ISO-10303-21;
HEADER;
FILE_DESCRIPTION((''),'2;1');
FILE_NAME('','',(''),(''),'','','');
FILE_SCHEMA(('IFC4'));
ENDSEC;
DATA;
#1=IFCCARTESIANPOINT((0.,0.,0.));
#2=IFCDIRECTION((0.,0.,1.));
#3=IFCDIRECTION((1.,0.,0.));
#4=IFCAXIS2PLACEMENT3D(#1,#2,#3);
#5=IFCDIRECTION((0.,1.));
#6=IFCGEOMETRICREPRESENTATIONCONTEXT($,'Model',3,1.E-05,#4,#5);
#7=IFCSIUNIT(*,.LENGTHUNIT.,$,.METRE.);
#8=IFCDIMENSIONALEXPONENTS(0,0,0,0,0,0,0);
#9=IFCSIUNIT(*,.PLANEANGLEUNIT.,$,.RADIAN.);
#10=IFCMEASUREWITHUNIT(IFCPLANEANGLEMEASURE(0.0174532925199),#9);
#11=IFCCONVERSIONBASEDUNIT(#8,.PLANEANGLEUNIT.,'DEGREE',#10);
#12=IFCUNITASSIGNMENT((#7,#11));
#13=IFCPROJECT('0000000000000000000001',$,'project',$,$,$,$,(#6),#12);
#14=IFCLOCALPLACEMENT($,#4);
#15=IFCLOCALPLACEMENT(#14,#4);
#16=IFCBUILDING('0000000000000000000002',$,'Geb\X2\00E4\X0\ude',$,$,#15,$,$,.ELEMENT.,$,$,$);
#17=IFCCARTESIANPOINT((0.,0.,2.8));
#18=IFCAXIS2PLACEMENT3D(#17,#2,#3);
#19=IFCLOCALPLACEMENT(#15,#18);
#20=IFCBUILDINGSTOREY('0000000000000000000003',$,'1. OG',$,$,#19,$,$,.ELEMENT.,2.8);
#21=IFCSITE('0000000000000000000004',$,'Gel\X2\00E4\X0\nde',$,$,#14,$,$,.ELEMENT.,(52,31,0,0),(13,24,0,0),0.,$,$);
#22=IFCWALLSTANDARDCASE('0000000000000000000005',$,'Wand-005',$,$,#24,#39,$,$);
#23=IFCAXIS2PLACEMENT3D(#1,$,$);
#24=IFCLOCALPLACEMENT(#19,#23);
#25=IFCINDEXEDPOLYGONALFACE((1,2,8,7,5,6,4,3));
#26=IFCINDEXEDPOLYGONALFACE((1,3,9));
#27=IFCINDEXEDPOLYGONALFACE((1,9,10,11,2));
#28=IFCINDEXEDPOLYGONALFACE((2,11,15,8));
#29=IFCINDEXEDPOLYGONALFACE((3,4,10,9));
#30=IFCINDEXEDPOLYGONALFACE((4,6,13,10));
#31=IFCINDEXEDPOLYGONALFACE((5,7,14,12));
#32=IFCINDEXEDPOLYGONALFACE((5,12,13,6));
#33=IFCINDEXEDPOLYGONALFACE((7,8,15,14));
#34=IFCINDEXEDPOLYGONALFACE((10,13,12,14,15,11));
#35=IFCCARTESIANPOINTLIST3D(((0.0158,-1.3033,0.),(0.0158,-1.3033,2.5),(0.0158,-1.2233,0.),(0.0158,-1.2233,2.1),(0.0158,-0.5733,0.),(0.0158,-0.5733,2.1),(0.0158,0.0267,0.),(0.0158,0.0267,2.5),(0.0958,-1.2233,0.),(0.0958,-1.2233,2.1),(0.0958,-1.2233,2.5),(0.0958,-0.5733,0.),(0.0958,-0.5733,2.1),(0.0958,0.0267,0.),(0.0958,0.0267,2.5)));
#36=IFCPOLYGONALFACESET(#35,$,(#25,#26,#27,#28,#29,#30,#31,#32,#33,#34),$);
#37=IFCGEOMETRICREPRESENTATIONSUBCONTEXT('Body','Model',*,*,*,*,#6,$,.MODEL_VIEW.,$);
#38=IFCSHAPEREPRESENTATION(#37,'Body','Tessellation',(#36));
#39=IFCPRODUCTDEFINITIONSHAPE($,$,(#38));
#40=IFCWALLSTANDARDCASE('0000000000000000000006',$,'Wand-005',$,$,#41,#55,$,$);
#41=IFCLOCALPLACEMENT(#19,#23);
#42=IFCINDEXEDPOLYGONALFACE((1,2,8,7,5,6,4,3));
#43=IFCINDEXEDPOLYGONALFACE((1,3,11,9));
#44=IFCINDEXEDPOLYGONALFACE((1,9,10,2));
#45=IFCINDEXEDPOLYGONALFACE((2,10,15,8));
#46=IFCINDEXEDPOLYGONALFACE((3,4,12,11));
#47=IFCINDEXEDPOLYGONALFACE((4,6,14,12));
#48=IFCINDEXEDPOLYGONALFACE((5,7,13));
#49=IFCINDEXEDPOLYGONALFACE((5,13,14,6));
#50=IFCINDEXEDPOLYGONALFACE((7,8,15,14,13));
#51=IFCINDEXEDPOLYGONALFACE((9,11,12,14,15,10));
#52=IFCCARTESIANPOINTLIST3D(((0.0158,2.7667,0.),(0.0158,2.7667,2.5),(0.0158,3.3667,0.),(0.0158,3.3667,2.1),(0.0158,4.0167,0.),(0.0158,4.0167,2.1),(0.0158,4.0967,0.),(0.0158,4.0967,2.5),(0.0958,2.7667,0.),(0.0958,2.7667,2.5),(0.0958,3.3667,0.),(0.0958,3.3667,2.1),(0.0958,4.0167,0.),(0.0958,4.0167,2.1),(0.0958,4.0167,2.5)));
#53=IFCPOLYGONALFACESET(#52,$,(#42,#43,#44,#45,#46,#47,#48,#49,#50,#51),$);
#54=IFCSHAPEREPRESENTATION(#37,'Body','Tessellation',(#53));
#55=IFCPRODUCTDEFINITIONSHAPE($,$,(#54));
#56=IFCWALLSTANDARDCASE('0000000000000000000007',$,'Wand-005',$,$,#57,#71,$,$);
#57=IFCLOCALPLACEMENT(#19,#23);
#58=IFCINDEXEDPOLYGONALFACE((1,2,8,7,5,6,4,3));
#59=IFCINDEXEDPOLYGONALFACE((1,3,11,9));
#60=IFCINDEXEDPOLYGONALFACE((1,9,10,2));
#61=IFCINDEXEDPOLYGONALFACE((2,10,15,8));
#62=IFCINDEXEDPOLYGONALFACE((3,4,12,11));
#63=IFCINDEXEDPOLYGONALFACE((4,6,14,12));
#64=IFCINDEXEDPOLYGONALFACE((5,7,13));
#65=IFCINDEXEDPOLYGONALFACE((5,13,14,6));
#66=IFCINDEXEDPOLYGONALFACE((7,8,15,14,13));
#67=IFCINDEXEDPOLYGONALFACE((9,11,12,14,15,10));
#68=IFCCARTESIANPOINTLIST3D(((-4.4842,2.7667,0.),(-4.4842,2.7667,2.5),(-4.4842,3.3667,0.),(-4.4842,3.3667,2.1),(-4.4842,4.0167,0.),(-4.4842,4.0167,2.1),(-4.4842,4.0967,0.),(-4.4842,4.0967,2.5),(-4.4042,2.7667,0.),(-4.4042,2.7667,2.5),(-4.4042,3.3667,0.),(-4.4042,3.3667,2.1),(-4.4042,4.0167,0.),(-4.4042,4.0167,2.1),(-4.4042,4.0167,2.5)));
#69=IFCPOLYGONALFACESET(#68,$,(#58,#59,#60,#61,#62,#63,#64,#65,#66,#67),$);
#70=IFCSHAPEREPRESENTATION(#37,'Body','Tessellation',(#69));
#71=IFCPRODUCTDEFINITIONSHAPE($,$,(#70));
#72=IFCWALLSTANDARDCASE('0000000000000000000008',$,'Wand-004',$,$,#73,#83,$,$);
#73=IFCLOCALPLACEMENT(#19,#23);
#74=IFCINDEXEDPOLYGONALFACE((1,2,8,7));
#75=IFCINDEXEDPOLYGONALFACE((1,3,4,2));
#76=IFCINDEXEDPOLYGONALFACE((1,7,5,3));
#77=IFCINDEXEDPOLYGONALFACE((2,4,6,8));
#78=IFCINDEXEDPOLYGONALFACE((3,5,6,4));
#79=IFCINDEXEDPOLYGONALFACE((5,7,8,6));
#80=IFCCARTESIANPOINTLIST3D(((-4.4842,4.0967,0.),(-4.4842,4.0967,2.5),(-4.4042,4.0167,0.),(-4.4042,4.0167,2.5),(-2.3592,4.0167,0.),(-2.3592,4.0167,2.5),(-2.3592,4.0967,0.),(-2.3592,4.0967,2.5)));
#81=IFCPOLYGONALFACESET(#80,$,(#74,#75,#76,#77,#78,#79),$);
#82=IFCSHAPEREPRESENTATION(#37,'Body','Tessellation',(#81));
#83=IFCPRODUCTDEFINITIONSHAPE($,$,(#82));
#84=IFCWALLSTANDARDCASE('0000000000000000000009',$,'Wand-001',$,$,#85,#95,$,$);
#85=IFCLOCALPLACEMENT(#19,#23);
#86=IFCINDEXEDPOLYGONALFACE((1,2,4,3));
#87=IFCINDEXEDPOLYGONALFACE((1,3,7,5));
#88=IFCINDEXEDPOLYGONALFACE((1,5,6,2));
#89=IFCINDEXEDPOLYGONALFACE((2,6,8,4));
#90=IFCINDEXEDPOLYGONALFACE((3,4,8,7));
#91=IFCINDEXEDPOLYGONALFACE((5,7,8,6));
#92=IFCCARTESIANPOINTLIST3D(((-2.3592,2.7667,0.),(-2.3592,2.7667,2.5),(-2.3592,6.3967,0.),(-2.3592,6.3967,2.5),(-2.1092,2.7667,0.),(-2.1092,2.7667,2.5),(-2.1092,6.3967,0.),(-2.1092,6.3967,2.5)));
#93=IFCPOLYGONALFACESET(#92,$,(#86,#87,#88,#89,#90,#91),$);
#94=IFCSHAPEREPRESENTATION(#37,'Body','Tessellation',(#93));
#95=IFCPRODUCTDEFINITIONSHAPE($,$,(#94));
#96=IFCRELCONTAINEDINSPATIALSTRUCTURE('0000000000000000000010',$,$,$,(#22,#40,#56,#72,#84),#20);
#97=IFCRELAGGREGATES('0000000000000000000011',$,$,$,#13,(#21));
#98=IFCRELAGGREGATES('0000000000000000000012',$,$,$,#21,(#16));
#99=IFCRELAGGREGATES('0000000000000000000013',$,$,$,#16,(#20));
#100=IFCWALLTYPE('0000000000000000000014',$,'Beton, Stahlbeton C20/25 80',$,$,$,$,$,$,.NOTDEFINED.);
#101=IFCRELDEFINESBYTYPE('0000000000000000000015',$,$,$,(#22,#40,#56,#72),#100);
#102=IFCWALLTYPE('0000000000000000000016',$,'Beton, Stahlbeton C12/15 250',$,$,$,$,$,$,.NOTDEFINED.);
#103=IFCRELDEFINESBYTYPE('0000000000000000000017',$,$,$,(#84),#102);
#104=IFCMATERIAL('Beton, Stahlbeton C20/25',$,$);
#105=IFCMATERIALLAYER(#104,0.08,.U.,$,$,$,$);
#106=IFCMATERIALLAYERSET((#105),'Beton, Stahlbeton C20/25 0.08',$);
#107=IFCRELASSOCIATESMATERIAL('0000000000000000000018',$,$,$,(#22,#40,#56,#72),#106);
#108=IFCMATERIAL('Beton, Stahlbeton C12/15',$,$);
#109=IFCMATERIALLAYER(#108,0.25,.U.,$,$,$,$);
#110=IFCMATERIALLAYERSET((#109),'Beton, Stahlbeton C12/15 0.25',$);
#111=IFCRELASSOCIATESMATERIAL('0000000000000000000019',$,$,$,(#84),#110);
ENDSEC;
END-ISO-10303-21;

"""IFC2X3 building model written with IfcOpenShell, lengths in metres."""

from ifc_helpers import new_model, entity, si_unit, converted_unit, direction, frame, origin_with_axes, origin_2d_with_axis, place, context, subcontext, project, spatial, polyline, rectangle, outline, extrude, material, layer, layer_set, layer_usage, type_object, element, save


model = new_model("IFC2X3")

# Units and contexts
model_context = context("Model", 3, precision=1e-05, world=origin_with_axes(), true_north=direction((0.0, 1.0)))
body_context = subcontext(model_context, "Body", "Model", "MODEL_VIEW")
ifc_project = project(units=[si_unit("LENGTHUNIT", "METRE"), converted_unit("PLANEANGLEUNIT", "DEGREE", entity("IfcPlaneAngleMeasure", 0.0174532925199), si_unit("PLANEANGLEUNIT", "RADIAN"), dimensions=[0, 0, 0, 0, 0, 0, 0])], contexts=[model_context])

# Site, building, storey
site_placement = place(None, origin_with_axes())
site = spatial("IfcSite", under=ifc_project, at=site_placement, Name="Gelände", CompositionType="ELEMENT", RefLatitude=(52, 31, 0, 0), RefLongitude=(13, 24, 0, 0), RefElevation=0.0)
building_placement = place(site_placement, origin_with_axes())
building = spatial("IfcBuilding", under=site, at=building_placement, Name="Gebäude", CompositionType="ELEMENT")
storey_placement = place(building_placement, frame((0.0, 0.0, 2.8), z_axis=(0.0, 0.0, 1.0), x_axis=(1.0, 0.0, 0.0)))
storey = spatial("IfcBuildingStorey", under=building, at=storey_placement, Name="1. OG", CompositionType="ELEMENT", Elevation=2.8)

# Walls, openings
ifc_material_1 = material(Name="Beton, Stahlbeton C20/25")
ifc_layer_1 = layer(ifc_material_1, 0.08, ventilated="UNKNOWN")
ifc_layer_set_1 = layer_set([ifc_layer_1], Name="Beton, Stahlbeton C20/25 0.08")
ifc_layer_usage_1 = layer_usage(ifc_layer_set_1, "AXIS2", "NEGATIVE", 0.0)
wall_type_1 = type_object("IfcWallType", Name="Beton, Stahlbeton C20/25 80", PredefinedType="NOTDEFINED")
wall_1_placement = place(storey_placement, frame((0.0158, -1.3033, 0.0), z_axis=(0.0, 0.0, 1.0), x_axis=(0.0, 1.0, 0.0)))
wall_1 = element("IfcWallStandardCase", 1, at=wall_1_placement, inside=storey, type_object=wall_type_1, material=ifc_layer_usage_1, Name="Wand-005", context=body_context, shape_type="SweptSolid", body=[
    extrude(outline(polyline([(0.08, -0.08), (1.33, -0.08), (1.33, 0.0), (0.0, 0.0), (0.08, -0.08)])), origin_with_axes(), (0.0, 0.0, 1.0), 2.5),
])
opening_1_placement = place(wall_1_placement, frame((0.405, 0.0, 0.0), z_axis=(0.0, 0.0, 1.0), x_axis=(1.0, 0.0, 0.0)))
element("IfcOpeningElement", 2, at=opening_1_placement, cuts=wall_1, context=body_context, shape_type="SweptSolid", body=[
    extrude(rectangle(XDim=0.65, YDim=2.1, at=origin_2d_with_axis()), frame((0.0, 0.08, 1.05), z_axis=(0.0, 1.0, 0.0), x_axis=(-1.0, 0.0, 0.0)), (0.0, 0.0, -1.0), 0.24),
])
ifc_layer_usage_2 = layer_usage(ifc_layer_set_1, "AXIS2", "POSITIVE", 0.0)
wall_2_placement = place(storey_placement, frame((0.0158, 4.0967, 0.0), z_axis=(0.0, 0.0, 1.0), x_axis=(0.0, -1.0, 0.0)))
wall_2 = element("IfcWallStandardCase", 3, at=wall_2_placement, inside=storey, type_object=wall_type_1, material=ifc_layer_usage_2, Name="Wand-005", context=body_context, shape_type="SweptSolid", body=[
    extrude(outline(polyline([(0.0, 0.0), (1.33, 0.0), (1.33, 0.08), (0.08, 0.08), (0.0, 0.0)])), origin_with_axes(), (0.0, 0.0, 1.0), 2.5),
])
opening_2_placement = place(wall_2_placement, frame((0.405, 0.0, 0.0), z_axis=(0.0, 0.0, 1.0), x_axis=(1.0, 0.0, 0.0)))
element("IfcOpeningElement", 4, at=opening_2_placement, cuts=wall_2, context=body_context, shape_type="SweptSolid", body=[
    extrude(rectangle(XDim=0.65, YDim=2.1, at=origin_2d_with_axis()), frame((0.0, -0.08, 1.05), z_axis=(0.0, 1.0, 0.0), x_axis=(-1.0, 0.0, 0.0)), (0.0, 0.0, 1.0), 0.24),
])
ifc_layer_usage_3 = layer_usage(ifc_layer_set_1, "AXIS2", "POSITIVE", 0.0)
wall_3_placement = place(storey_placement, frame((-4.4842, 4.0967, 0.0), z_axis=(0.0, 0.0, 1.0), x_axis=(0.0, -1.0, 0.0)))
wall_3 = element("IfcWallStandardCase", 5, at=wall_3_placement, inside=storey, type_object=wall_type_1, material=ifc_layer_usage_3, Name="Wand-005", context=body_context, shape_type="SweptSolid", body=[
    extrude(outline(polyline([(0.0, 0.0), (1.33, 0.0), (1.33, 0.08), (0.08, 0.08), (0.0, 0.0)])), origin_with_axes(), (0.0, 0.0, 1.0), 2.5),
])
opening_3_placement = place(wall_3_placement, frame((0.405, 0.0, 0.0), z_axis=(0.0, 0.0, 1.0), x_axis=(1.0, 0.0, 0.0)))
element("IfcOpeningElement", 6, at=opening_3_placement, cuts=wall_3, context=body_context, shape_type="SweptSolid", body=[
    extrude(rectangle(XDim=0.65, YDim=2.1, at=origin_2d_with_axis()), frame((0.0, -0.08, 1.05), z_axis=(0.0, 1.0, 0.0), x_axis=(-1.0, 0.0, 0.0)), (0.0, 0.0, 1.0), 0.24),
])

# Walls
ifc_layer_usage_4 = layer_usage(ifc_layer_set_1, "AXIS2", "POSITIVE", 0.0)
wall_4_placement = place(storey_placement, frame((-2.3592, 4.0967, 0.0), z_axis=(0.0, 0.0, 1.0), x_axis=(-1.0, 0.0, 0.0)))
element("IfcWallStandardCase", 7, at=wall_4_placement, inside=storey, type_object=wall_type_1, material=ifc_layer_usage_4, Name="Wand-004", context=body_context, shape_type="SweptSolid", body=[
    extrude(outline(polyline([(0.0, 0.0), (2.125, 0.0), (2.045, 0.08), (0.0, 0.08), (0.0, 0.0)])), origin_with_axes(), (0.0, 0.0, 1.0), 2.5),
])
ifc_material_2 = material(Name="Beton, Stahlbeton C12/15")
ifc_layer_2 = layer(ifc_material_2, 0.25, ventilated="UNKNOWN")
ifc_layer_set_2 = layer_set([ifc_layer_2], Name="Beton, Stahlbeton C12/15 0.25")
ifc_layer_usage_5 = layer_usage(ifc_layer_set_2, "AXIS2", "NEGATIVE", 0.0)
wall_type_2 = type_object("IfcWallType", Name="Beton, Stahlbeton C12/15 250", PredefinedType="NOTDEFINED")
wall_5_placement = place(storey_placement, frame((-2.1092, 6.3967, 0.0), z_axis=(0.0, 0.0, 1.0), x_axis=(0.0, -1.0, 0.0)))
element("IfcWallStandardCase", 8, at=wall_5_placement, inside=storey, type_object=wall_type_2, material=ifc_layer_usage_5, Name="Wand-001", context=body_context, shape_type="SweptSolid", body=[
    extrude(outline(polyline([(0.0, -0.25), (3.63, -0.25), (3.63, 0.0), (0.0, 0.0), (0.0, -0.25)])), origin_with_axes(), (0.0, 0.0, 1.0), 2.5),
])

save(model, "model.ifc")
